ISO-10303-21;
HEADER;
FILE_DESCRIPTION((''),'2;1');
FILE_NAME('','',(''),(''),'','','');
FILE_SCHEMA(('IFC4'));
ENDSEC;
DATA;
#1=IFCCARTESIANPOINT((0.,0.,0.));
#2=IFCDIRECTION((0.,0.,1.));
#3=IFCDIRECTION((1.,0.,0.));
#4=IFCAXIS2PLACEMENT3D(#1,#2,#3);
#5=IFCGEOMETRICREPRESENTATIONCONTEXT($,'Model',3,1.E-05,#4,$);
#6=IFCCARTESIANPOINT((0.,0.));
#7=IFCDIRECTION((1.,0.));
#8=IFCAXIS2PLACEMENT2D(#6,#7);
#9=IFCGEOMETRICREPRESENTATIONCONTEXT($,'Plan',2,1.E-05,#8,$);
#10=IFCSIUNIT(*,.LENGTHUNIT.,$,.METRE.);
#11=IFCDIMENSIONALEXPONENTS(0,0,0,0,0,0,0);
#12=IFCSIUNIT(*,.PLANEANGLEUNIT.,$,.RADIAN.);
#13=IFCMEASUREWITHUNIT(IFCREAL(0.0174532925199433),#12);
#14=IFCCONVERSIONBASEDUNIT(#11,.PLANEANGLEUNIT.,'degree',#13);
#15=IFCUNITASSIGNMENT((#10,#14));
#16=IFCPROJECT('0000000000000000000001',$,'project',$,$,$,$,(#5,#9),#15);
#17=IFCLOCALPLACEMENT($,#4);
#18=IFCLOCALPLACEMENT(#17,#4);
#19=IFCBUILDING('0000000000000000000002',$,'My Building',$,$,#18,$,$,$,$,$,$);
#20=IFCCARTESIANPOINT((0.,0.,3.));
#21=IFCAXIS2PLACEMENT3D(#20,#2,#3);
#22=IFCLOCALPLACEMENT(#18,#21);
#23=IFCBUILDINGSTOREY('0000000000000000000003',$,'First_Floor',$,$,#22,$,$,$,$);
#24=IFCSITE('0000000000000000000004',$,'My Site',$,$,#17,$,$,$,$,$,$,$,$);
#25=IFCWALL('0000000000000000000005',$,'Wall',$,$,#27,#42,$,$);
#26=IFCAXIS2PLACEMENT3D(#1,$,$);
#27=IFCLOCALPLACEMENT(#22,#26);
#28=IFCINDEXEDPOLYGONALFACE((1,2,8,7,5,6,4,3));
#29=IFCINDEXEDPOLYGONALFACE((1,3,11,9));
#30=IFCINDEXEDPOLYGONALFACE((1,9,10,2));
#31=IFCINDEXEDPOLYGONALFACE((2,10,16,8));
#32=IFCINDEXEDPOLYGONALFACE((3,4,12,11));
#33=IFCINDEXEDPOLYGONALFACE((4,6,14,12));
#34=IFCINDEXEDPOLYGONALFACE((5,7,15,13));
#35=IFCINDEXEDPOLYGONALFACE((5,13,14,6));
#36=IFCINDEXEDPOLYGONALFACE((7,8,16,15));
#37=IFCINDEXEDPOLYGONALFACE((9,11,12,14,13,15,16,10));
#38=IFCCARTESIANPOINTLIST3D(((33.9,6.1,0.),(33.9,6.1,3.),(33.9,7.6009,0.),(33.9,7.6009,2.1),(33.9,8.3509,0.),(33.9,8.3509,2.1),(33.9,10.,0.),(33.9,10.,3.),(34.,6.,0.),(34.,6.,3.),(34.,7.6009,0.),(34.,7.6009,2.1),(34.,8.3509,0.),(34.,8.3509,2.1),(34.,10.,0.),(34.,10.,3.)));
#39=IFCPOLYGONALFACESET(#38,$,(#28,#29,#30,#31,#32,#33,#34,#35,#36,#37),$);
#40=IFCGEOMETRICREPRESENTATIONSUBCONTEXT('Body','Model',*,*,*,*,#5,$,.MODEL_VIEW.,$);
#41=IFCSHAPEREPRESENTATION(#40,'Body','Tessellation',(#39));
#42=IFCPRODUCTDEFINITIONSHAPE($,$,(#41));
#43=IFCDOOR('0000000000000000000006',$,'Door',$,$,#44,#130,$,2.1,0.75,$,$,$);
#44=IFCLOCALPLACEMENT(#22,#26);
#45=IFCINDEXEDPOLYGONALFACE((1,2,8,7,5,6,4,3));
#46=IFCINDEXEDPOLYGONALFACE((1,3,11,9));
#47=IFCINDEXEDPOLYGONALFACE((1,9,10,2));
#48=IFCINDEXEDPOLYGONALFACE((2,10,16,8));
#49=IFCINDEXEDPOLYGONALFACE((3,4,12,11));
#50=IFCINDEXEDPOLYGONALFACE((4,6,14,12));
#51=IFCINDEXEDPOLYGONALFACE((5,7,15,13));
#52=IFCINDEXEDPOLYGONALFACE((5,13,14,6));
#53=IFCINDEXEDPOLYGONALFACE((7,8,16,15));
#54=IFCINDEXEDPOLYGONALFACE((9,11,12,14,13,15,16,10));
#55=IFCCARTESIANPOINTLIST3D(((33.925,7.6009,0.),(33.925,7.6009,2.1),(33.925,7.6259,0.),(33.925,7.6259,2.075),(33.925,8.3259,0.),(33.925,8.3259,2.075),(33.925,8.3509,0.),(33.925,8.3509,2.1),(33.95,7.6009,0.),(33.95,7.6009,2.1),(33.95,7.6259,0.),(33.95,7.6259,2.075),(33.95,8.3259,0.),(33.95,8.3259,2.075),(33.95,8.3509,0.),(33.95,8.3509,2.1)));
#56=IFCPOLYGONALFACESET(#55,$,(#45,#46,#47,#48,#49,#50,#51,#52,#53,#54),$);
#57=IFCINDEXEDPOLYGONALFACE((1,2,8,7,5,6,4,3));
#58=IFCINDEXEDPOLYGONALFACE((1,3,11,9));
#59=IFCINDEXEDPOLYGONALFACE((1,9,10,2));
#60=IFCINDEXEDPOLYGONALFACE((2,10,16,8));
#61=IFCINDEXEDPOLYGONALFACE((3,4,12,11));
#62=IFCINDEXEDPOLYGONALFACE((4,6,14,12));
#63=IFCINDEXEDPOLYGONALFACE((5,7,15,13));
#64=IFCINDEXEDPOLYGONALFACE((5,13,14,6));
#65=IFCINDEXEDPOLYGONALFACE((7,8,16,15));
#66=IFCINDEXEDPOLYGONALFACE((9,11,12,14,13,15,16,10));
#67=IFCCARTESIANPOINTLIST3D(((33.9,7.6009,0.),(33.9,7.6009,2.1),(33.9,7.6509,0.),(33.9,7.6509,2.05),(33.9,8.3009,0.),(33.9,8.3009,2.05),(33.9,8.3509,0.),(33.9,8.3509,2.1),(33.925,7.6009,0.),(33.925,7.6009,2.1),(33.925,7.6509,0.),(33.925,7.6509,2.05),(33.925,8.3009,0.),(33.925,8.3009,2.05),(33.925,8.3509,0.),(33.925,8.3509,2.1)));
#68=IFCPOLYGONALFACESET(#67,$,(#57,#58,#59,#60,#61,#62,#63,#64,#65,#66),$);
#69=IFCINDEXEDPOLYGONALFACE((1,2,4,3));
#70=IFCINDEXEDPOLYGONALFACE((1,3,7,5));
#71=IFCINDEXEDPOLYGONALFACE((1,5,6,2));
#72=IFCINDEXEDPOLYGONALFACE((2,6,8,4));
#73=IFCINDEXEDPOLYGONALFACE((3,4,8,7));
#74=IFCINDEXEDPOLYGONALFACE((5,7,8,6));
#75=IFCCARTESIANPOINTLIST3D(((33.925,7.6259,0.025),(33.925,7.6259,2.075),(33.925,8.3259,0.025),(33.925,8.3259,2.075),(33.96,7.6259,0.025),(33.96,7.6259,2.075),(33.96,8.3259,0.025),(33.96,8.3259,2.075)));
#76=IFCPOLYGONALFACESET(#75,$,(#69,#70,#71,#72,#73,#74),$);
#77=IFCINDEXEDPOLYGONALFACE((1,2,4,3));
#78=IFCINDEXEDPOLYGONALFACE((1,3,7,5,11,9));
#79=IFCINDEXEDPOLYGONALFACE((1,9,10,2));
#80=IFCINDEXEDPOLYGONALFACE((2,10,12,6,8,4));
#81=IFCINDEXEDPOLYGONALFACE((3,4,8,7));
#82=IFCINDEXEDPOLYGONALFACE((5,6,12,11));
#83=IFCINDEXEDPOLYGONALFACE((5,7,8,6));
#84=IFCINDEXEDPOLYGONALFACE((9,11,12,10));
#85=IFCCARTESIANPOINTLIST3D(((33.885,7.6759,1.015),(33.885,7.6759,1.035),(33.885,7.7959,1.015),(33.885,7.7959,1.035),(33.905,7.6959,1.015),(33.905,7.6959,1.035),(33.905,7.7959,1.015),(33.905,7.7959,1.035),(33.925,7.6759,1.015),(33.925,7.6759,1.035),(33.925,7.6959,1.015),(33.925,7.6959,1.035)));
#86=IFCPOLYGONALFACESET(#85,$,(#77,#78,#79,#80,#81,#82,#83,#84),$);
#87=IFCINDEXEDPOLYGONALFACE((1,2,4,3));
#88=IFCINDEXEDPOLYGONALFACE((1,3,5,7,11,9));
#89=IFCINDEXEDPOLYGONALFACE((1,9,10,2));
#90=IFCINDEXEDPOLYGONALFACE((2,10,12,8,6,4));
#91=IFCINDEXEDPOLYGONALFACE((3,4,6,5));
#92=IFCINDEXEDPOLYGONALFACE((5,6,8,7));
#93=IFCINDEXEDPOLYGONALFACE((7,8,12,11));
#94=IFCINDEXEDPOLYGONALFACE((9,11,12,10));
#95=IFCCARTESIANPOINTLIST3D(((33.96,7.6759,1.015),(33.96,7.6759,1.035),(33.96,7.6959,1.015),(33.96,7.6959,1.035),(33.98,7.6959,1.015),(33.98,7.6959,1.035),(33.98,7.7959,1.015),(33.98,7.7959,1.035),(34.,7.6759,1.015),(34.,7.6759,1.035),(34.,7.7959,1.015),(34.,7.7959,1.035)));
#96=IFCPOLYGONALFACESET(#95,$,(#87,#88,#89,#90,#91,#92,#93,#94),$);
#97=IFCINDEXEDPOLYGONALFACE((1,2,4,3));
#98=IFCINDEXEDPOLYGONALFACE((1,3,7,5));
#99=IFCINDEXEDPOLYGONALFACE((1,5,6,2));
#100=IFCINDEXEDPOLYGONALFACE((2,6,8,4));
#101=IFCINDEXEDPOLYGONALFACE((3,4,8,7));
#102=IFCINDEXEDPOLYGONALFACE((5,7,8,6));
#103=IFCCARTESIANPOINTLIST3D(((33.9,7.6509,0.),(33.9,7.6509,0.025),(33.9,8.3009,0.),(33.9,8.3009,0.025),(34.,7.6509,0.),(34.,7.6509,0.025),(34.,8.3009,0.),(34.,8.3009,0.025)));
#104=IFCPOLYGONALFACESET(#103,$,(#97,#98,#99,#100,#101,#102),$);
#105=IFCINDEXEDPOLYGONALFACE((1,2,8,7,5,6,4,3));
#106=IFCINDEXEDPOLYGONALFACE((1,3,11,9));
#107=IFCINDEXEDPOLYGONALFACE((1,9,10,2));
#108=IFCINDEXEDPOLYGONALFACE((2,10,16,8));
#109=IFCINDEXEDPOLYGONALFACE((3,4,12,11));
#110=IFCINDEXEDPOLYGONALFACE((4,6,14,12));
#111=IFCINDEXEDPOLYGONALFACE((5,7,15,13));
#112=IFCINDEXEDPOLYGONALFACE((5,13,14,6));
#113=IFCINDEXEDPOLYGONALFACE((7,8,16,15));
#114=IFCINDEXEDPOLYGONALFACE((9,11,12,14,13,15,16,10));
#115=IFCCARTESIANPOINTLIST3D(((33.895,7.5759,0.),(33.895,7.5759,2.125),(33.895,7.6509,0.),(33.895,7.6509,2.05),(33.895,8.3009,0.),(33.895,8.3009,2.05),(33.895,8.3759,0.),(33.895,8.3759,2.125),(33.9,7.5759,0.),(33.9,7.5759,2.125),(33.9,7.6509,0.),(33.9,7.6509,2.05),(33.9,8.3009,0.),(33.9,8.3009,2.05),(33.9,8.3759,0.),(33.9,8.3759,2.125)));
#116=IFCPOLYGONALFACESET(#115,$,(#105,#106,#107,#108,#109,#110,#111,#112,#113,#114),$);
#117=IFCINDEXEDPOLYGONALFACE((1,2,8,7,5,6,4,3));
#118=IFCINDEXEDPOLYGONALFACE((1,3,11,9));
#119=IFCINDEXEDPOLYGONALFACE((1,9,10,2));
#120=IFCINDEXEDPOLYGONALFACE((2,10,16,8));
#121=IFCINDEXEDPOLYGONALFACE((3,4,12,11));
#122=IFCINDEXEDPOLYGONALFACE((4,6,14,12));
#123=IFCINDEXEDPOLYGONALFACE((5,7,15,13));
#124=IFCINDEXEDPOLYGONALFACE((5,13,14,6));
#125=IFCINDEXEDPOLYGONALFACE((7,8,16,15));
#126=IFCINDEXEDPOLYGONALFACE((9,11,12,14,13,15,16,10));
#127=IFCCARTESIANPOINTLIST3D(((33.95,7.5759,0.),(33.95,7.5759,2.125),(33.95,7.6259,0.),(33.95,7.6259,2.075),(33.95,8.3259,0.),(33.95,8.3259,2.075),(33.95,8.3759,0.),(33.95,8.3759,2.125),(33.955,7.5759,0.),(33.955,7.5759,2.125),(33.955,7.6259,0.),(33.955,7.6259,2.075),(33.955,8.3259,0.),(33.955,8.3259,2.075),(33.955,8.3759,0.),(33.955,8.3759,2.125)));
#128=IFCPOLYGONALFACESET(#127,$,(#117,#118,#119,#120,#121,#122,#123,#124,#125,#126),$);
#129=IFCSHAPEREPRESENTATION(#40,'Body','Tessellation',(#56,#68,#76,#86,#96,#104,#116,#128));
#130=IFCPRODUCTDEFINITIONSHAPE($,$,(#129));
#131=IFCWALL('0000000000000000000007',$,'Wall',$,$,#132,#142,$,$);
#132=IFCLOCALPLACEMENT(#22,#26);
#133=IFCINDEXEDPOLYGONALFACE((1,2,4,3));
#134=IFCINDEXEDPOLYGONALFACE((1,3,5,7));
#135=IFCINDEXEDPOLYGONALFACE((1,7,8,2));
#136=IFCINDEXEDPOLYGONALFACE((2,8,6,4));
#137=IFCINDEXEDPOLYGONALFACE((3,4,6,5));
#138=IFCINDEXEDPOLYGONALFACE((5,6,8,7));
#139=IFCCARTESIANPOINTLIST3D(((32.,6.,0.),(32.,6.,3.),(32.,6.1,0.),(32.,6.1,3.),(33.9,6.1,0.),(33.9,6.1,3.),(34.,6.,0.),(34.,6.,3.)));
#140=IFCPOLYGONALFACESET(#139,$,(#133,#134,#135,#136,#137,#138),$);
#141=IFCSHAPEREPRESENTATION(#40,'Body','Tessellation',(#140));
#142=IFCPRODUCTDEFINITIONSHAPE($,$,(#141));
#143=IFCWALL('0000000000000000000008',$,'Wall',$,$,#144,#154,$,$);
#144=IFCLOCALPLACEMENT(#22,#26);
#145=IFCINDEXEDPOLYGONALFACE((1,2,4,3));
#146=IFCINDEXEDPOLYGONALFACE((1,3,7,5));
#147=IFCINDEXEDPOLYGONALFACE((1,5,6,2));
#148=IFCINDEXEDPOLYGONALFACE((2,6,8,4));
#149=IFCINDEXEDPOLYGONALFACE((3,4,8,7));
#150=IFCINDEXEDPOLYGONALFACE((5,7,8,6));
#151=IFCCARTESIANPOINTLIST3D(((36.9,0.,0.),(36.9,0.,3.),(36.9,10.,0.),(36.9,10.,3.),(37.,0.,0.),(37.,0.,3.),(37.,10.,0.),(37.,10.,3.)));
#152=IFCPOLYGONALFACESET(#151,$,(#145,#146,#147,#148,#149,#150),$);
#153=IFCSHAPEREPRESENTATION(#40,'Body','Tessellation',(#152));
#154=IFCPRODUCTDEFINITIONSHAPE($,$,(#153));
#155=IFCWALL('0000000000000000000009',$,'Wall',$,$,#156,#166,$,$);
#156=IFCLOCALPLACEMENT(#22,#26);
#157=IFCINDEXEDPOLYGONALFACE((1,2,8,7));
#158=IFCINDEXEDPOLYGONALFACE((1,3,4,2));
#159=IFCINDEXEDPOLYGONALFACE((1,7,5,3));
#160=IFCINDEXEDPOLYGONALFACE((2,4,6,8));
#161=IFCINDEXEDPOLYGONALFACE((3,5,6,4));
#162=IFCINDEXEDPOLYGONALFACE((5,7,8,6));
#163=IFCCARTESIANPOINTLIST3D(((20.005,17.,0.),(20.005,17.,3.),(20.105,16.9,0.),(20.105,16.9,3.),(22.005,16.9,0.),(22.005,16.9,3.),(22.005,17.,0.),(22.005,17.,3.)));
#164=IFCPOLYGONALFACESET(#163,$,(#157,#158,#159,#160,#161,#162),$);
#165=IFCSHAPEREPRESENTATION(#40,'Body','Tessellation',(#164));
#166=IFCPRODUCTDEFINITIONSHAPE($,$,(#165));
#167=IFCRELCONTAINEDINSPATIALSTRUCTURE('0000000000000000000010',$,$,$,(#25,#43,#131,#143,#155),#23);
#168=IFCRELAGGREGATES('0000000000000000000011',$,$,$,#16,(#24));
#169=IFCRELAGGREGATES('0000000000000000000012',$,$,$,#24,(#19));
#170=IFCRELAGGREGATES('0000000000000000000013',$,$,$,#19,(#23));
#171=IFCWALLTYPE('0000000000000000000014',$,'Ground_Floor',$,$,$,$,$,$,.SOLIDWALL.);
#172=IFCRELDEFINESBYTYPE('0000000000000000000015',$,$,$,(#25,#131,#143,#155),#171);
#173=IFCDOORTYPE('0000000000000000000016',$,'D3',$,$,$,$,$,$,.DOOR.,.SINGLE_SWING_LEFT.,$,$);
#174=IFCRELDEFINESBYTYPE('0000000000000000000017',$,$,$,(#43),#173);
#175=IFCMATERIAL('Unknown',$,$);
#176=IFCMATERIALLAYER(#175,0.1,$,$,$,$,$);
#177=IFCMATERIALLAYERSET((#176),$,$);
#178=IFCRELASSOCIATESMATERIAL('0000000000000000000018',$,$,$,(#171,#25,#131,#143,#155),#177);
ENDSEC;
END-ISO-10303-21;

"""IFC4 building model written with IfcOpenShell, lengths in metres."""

from ifc_helpers import new_model, entity, si_unit, converted_unit, frame, origin_with_axes, origin_2d_with_axis, place, context, subcontext, project, spatial, line, indexed_curve, outline, extrude, shape, source, transform, mapped, material, layer, layer_set, layer_usage, type_object, type_shapes, element, fill, save


model = new_model("IFC4")

# Units and contexts
model_context = context("Model", 3, precision=1e-05, world=origin_with_axes())
plan_context = context("Plan", 2, precision=1e-05, world=origin_2d_with_axis())
body_context_1 = subcontext(model_context, "Body", "Model", "MODEL_VIEW")
body_context_2 = subcontext(plan_context, "Body", "Plan", "PLAN_VIEW")
ifc_project = project(units=[si_unit("LENGTHUNIT", "METRE"), converted_unit("PLANEANGLEUNIT", "degree", entity("IfcReal", 0.0174532925199433), si_unit("PLANEANGLEUNIT", "RADIAN"), dimensions=[0, 0, 0, 0, 0, 0, 0])], contexts=[model_context, plan_context])

# Site, building, storey
site_placement = place(None, origin_with_axes())
site = spatial("IfcSite", under=ifc_project, at=site_placement, Name="My Site")
building_placement = place(site_placement, origin_with_axes())
building = spatial("IfcBuilding", under=site, at=building_placement, Name="My Building")
storey_placement = place(building_placement, frame((0.0, 0.0, 3.0), z_axis=(0.0, 0.0, 1.0), x_axis=(1.0, 0.0, 0.0)))
storey = spatial("IfcBuildingStorey", under=building, at=storey_placement, Name="First_Floor")

# Shared definitions
ifc_material = material(Name="Unknown")

# Shared definitions
ifc_layer = layer(ifc_material, 0.1)
ifc_layer_set = layer_set([ifc_layer])
wall_type = type_object("IfcWallType", Name="Ground_Floor", PredefinedType="SOLIDWALL", material=ifc_layer_set)
shared_shape_1 = source(origin_with_axes(), body_context_1, "Body", "SweptSolid", [
    extrude(outline(indexed_curve([(0.0, 0.0), (0.75, 0.0), (0.75, 2.1), (0.0, 2.1)], segments=[line(1, 2, 3, 4, 1)])), frame((0.0, -0.6, 0.0), z_axis=(0.0, -1.0, 0.0), x_axis=(1.0, 0.0, 0.0)), (0.0, 0.0, -1.0), 1.2),
])
door_type_1 = type_object("IfcDoorType", Name="D3", OperationType="SINGLE_SWING_LEFT", PredefinedType="DOOR")
shared_shape_2 = source(origin_with_axes(), body_context_1, "Body", "SweptSolid", [
    extrude(outline(indexed_curve([(0.0, 0.0), (0.0, 2.1), (0.75, 2.1), (0.75, 0.0), (0.725, 0.0), (0.725, 2.075), (0.025, 2.075), (0.025, 0.0)], segments=[line(1, 2, 3, 4, 5, 6, 7, 8, 1)])), frame((0.0, 0.025, 0.0), z_axis=(0.0, -1.0, 0.0), x_axis=(1.0, 0.0, 0.0)), (0.0, 0.0, -1.0), 0.025),
    extrude(outline(indexed_curve([(0.0, 0.0), (0.0, 2.1), (0.75, 2.1), (0.75, 0.0), (0.7, 0.0), (0.7, 2.05), (0.05, 2.05), (0.05, 0.0)], segments=[line(1, 2, 3, 4, 5, 6, 7, 8, 1)])), frame((0.0, 0.0, 0.0), z_axis=(0.0, -1.0, 0.0), x_axis=(1.0, 0.0, 0.0)), (0.0, 0.0, -1.0), 0.025),
    extrude(outline(indexed_curve([(0.0, 0.0), (0.7, 0.0), (0.7, 0.035), (0.0, 0.035)], segments=[line(1, 2, 3, 4, 1)])), frame((0.025, 0.025, 0.025), z_axis=(0.0, 0.0, 1.0), x_axis=(1.0, 0.0, 0.0)), (0.0, 0.0, 1.0), 2.05),
    extrude(outline(indexed_curve([(0.0, 0.0), (0.0, -0.04), (-0.12, -0.04), (-0.12, -0.02), (-0.02, -0.02), (-0.02, 0.0)], segments=[line(1, 2, 3, 4, 5, 6, 1)])), frame((0.675, 0.025, 1.015), z_axis=(0.0, 0.0, 1.0), x_axis=(1.0, 0.0, 0.0)), (0.0, 0.0, 1.0), 0.02),
    extrude(outline(indexed_curve([(0.0, 0.0), (0.0, 0.04), (-0.12, 0.04), (-0.12, 0.02), (-0.02, 0.02), (-0.02, 0.0)], segments=[line(1, 2, 3, 4, 5, 6, 1)])), frame((0.675, 0.06, 1.015), z_axis=(0.0, 0.0, 1.0), x_axis=(1.0, 0.0, 0.0)), (0.0, 0.0, 1.0), 0.02),
    extrude(outline(indexed_curve([(0.0, 0.0), (0.65, 0.0), (0.65, 0.1), (0.0, 0.1)], segments=[line(1, 2, 3, 4, 1)])), frame((0.05, 0.0, 0.0), z_axis=(0.0, 0.0, 1.0), x_axis=(1.0, 0.0, 0.0)), (0.0, 0.0, 1.0), 0.025),
    extrude(outline(indexed_curve([(0.0, 0.0), (0.0, 2.125), (0.8, 2.125), (0.8, 0.0), (0.725, 0.0), (0.725, 2.05), (0.075, 2.05), (0.075, 0.0)], segments=[line(1, 2, 3, 4, 5, 6, 7, 8, 1)])), frame((-0.025, -0.005, 0.0), z_axis=(0.0, -1.0, 0.0), x_axis=(1.0, 0.0, 0.0)), (0.0, 0.0, -1.0), 0.005),
    extrude(outline(indexed_curve([(0.0, 0.0), (0.0, 2.125), (0.8, 2.125), (0.8, 0.0), (0.75, 0.0), (0.75, 2.075), (0.05, 2.075), (0.05, 0.0)], segments=[line(1, 2, 3, 4, 5, 6, 7, 8, 1)])), frame((-0.025, 0.05, 0.0), z_axis=(0.0, -1.0, 0.0), x_axis=(1.0, 0.0, 0.0)), (0.0, 0.0, -1.0), 0.005),
])
shared_shape_3 = source(origin_with_axes(), body_context_2, "Body", "Curve2D", [
    entity("IfcIndexedPolyCurve", entity("IfcCartesianPointList2D", [[0.0, 0.0], [0.0, 0.05], [0.025, 0.05], [0.025, 0.025], [0.05, 0.025], [0.05, 0.0]]), [entity("IfcLineIndex", [1, 2, 3, 4, 5, 6, 1])]),
    entity("IfcIndexedPolyCurve", entity("IfcCartesianPointList2D", [[0.75, 0.0], [0.75, 0.05], [0.725, 0.05], [0.725, 0.025], [0.7, 0.025], [0.7, 0.0]]), [entity("IfcLineIndex", [1, 2, 3, 4, 5, 6, 1])]),
    entity("IfcTrimmedCurve", entity("IfcEllipse", entity("IfcAxis2Placement2D", entity("IfcCartesianPoint", [0.06, 0.05]), entity("IfcDirection", [1.0, 0.0])), 0.665, 0.7), [entity("IfcCartesianPoint", [0.725, 0.05])], [entity("IfcCartesianPoint", [0.06, 0.75])], True, "CARTESIAN"),
    entity("IfcIndexedPolyCurve", entity("IfcCartesianPointList2D", [[0.025, 0.05], [0.06, 0.05], [0.06, 0.75], [0.025, 0.75]]), [entity("IfcLineIndex", [1, 2, 3, 4, 1])]),
])
type_shapes(door_type_1, [shared_shape_2, shared_shape_3])

# Wall, opening, door
ifc_layer_usage_1 = layer_usage(ifc_layer_set, "AXIS2", "POSITIVE", 0.0)
wall_1_placement = place(storey_placement, frame((34.0, 6.0, 0.0), z_axis=(0.0, 0.0, 1.0), x_axis=(0.0, 1.0, 0.0)))
wall_1 = element("IfcWall", 1, at=wall_1_placement, inside=storey, type_object=wall_type, material=ifc_layer_usage_1, Name="Wall", context=body_context_1, shape_type="SweptSolid", body=[
    extrude(outline(indexed_curve([(0.0, 0.0), (0.1, 0.1), (4.0, 0.1), (4.0, 0.0)], segments=[line(1, 2, 3, 4, 1)])), origin_with_axes(), (0.0, 0.0, 1.0), 3.0),
])
opening_1_placement = place(wall_1_placement, frame((2.3509, 0.1, 0.0), z_axis=(0.0, 0.0, 1.0), x_axis=(-1.0, 0.0, 0.0)))
opening_1 = element("IfcOpeningElement", 2, at=opening_1_placement, cuts=wall_1, PredefinedType="OPENING", context=body_context_1, shape_type="MappedRepresentation", body=[
    mapped(shared_shape_1, transform((0.0, 0.0, 0.0), x_axis=(1.0, 0.0, 0.0), y_axis=(0.0, 1.0, 0.0), z_axis=(0.0, 0.0, 1.0), scale=1.0)),
])
door_1_placement = place(opening_1_placement, frame((0.0, 0.0, 0.0), z_axis=(0.0, 0.0, 1.0), x_axis=(1.0, 0.0, 0.0)))
door_1 = element("IfcDoor", 3, at=door_1_placement, inside=storey, type_object=door_type_1, Name="Door", OverallHeight=2.1, OverallWidth=0.75, shapes=[
    shape(body_context_1, "Body", "MappedRepresentation", [mapped(shared_shape_2, transform((0.0, 0.0, 0.0), x_axis=(1.0, 0.0, 0.0), y_axis=(0.0, 1.0, 0.0), z_axis=(0.0, 0.0, 1.0), scale=1.0))]),
    shape(body_context_2, "Body", "MappedRepresentation", [mapped(shared_shape_3, transform((0.0, 0.0, 0.0), x_axis=(1.0, 0.0, 0.0), y_axis=(0.0, 1.0, 0.0), z_axis=(0.0, 0.0, 1.0), scale=1.0))]),
])
fill(opening_1, door_1)

# Walls
ifc_layer_usage_2 = layer_usage(ifc_layer_set, "AXIS2", "POSITIVE", 0.0)
wall_2_placement = place(storey_placement, frame((32.0, 6.0, 0.0), z_axis=(0.0, 0.0, 1.0), x_axis=(1.0, 0.0, 0.0)))
element("IfcWall", 4, at=wall_2_placement, inside=storey, type_object=wall_type, material=ifc_layer_usage_2, Name="Wall", context=body_context_1, shape_type="SweptSolid", body=[
    extrude(outline(indexed_curve([(0.0, 0.0), (0.0, 0.1), (1.9, 0.1), (2.0, 0.0)], segments=[line(1, 2, 3, 4, 1)])), origin_with_axes(), (0.0, 0.0, 1.0), 3.0),
])
ifc_layer_usage_3 = layer_usage(ifc_layer_set, "AXIS2", "POSITIVE", 0.0)
wall_3_placement = place(storey_placement, frame((36.9, 10.0, 0.0), z_axis=(0.0, 0.0, 1.0), x_axis=(0.0, -1.0, 0.0)))
element("IfcWall", 5, at=wall_3_placement, inside=storey, type_object=wall_type, material=ifc_layer_usage_3, Name="Wall", context=body_context_1, shape_type="SweptSolid", body=[
    extrude(outline(indexed_curve([(0.0, 0.0), (0.0, 0.1), (10.0, 0.1), (10.0, 0.0)], segments=[line(1, 2, 3, 4, 1)])), origin_with_axes(), (0.0, 0.0, 1.0), 3.0),
])
ifc_layer_usage_4 = layer_usage(ifc_layer_set, "AXIS2", "POSITIVE", 0.0)
wall_4_placement = place(storey_placement, frame((22.005, 17.0, 0.0), z_axis=(0.0, 0.0, 1.0), x_axis=(-1.0, 0.0, 0.0)))
element("IfcWall", 6, at=wall_4_placement, inside=storey, type_object=wall_type, material=ifc_layer_usage_4, Name="Wall", context=body_context_1, shape_type="SweptSolid", body=[
    extrude(outline(indexed_curve([(0.0, 0.0), (0.0, 0.1), (1.9, 0.1), (2.0, 0.0)], segments=[line(1, 2, 3, 4, 1)])), origin_with_axes(), (0.0, 0.0, 1.0), 3.0),
])

save(model, "model.ifc")
